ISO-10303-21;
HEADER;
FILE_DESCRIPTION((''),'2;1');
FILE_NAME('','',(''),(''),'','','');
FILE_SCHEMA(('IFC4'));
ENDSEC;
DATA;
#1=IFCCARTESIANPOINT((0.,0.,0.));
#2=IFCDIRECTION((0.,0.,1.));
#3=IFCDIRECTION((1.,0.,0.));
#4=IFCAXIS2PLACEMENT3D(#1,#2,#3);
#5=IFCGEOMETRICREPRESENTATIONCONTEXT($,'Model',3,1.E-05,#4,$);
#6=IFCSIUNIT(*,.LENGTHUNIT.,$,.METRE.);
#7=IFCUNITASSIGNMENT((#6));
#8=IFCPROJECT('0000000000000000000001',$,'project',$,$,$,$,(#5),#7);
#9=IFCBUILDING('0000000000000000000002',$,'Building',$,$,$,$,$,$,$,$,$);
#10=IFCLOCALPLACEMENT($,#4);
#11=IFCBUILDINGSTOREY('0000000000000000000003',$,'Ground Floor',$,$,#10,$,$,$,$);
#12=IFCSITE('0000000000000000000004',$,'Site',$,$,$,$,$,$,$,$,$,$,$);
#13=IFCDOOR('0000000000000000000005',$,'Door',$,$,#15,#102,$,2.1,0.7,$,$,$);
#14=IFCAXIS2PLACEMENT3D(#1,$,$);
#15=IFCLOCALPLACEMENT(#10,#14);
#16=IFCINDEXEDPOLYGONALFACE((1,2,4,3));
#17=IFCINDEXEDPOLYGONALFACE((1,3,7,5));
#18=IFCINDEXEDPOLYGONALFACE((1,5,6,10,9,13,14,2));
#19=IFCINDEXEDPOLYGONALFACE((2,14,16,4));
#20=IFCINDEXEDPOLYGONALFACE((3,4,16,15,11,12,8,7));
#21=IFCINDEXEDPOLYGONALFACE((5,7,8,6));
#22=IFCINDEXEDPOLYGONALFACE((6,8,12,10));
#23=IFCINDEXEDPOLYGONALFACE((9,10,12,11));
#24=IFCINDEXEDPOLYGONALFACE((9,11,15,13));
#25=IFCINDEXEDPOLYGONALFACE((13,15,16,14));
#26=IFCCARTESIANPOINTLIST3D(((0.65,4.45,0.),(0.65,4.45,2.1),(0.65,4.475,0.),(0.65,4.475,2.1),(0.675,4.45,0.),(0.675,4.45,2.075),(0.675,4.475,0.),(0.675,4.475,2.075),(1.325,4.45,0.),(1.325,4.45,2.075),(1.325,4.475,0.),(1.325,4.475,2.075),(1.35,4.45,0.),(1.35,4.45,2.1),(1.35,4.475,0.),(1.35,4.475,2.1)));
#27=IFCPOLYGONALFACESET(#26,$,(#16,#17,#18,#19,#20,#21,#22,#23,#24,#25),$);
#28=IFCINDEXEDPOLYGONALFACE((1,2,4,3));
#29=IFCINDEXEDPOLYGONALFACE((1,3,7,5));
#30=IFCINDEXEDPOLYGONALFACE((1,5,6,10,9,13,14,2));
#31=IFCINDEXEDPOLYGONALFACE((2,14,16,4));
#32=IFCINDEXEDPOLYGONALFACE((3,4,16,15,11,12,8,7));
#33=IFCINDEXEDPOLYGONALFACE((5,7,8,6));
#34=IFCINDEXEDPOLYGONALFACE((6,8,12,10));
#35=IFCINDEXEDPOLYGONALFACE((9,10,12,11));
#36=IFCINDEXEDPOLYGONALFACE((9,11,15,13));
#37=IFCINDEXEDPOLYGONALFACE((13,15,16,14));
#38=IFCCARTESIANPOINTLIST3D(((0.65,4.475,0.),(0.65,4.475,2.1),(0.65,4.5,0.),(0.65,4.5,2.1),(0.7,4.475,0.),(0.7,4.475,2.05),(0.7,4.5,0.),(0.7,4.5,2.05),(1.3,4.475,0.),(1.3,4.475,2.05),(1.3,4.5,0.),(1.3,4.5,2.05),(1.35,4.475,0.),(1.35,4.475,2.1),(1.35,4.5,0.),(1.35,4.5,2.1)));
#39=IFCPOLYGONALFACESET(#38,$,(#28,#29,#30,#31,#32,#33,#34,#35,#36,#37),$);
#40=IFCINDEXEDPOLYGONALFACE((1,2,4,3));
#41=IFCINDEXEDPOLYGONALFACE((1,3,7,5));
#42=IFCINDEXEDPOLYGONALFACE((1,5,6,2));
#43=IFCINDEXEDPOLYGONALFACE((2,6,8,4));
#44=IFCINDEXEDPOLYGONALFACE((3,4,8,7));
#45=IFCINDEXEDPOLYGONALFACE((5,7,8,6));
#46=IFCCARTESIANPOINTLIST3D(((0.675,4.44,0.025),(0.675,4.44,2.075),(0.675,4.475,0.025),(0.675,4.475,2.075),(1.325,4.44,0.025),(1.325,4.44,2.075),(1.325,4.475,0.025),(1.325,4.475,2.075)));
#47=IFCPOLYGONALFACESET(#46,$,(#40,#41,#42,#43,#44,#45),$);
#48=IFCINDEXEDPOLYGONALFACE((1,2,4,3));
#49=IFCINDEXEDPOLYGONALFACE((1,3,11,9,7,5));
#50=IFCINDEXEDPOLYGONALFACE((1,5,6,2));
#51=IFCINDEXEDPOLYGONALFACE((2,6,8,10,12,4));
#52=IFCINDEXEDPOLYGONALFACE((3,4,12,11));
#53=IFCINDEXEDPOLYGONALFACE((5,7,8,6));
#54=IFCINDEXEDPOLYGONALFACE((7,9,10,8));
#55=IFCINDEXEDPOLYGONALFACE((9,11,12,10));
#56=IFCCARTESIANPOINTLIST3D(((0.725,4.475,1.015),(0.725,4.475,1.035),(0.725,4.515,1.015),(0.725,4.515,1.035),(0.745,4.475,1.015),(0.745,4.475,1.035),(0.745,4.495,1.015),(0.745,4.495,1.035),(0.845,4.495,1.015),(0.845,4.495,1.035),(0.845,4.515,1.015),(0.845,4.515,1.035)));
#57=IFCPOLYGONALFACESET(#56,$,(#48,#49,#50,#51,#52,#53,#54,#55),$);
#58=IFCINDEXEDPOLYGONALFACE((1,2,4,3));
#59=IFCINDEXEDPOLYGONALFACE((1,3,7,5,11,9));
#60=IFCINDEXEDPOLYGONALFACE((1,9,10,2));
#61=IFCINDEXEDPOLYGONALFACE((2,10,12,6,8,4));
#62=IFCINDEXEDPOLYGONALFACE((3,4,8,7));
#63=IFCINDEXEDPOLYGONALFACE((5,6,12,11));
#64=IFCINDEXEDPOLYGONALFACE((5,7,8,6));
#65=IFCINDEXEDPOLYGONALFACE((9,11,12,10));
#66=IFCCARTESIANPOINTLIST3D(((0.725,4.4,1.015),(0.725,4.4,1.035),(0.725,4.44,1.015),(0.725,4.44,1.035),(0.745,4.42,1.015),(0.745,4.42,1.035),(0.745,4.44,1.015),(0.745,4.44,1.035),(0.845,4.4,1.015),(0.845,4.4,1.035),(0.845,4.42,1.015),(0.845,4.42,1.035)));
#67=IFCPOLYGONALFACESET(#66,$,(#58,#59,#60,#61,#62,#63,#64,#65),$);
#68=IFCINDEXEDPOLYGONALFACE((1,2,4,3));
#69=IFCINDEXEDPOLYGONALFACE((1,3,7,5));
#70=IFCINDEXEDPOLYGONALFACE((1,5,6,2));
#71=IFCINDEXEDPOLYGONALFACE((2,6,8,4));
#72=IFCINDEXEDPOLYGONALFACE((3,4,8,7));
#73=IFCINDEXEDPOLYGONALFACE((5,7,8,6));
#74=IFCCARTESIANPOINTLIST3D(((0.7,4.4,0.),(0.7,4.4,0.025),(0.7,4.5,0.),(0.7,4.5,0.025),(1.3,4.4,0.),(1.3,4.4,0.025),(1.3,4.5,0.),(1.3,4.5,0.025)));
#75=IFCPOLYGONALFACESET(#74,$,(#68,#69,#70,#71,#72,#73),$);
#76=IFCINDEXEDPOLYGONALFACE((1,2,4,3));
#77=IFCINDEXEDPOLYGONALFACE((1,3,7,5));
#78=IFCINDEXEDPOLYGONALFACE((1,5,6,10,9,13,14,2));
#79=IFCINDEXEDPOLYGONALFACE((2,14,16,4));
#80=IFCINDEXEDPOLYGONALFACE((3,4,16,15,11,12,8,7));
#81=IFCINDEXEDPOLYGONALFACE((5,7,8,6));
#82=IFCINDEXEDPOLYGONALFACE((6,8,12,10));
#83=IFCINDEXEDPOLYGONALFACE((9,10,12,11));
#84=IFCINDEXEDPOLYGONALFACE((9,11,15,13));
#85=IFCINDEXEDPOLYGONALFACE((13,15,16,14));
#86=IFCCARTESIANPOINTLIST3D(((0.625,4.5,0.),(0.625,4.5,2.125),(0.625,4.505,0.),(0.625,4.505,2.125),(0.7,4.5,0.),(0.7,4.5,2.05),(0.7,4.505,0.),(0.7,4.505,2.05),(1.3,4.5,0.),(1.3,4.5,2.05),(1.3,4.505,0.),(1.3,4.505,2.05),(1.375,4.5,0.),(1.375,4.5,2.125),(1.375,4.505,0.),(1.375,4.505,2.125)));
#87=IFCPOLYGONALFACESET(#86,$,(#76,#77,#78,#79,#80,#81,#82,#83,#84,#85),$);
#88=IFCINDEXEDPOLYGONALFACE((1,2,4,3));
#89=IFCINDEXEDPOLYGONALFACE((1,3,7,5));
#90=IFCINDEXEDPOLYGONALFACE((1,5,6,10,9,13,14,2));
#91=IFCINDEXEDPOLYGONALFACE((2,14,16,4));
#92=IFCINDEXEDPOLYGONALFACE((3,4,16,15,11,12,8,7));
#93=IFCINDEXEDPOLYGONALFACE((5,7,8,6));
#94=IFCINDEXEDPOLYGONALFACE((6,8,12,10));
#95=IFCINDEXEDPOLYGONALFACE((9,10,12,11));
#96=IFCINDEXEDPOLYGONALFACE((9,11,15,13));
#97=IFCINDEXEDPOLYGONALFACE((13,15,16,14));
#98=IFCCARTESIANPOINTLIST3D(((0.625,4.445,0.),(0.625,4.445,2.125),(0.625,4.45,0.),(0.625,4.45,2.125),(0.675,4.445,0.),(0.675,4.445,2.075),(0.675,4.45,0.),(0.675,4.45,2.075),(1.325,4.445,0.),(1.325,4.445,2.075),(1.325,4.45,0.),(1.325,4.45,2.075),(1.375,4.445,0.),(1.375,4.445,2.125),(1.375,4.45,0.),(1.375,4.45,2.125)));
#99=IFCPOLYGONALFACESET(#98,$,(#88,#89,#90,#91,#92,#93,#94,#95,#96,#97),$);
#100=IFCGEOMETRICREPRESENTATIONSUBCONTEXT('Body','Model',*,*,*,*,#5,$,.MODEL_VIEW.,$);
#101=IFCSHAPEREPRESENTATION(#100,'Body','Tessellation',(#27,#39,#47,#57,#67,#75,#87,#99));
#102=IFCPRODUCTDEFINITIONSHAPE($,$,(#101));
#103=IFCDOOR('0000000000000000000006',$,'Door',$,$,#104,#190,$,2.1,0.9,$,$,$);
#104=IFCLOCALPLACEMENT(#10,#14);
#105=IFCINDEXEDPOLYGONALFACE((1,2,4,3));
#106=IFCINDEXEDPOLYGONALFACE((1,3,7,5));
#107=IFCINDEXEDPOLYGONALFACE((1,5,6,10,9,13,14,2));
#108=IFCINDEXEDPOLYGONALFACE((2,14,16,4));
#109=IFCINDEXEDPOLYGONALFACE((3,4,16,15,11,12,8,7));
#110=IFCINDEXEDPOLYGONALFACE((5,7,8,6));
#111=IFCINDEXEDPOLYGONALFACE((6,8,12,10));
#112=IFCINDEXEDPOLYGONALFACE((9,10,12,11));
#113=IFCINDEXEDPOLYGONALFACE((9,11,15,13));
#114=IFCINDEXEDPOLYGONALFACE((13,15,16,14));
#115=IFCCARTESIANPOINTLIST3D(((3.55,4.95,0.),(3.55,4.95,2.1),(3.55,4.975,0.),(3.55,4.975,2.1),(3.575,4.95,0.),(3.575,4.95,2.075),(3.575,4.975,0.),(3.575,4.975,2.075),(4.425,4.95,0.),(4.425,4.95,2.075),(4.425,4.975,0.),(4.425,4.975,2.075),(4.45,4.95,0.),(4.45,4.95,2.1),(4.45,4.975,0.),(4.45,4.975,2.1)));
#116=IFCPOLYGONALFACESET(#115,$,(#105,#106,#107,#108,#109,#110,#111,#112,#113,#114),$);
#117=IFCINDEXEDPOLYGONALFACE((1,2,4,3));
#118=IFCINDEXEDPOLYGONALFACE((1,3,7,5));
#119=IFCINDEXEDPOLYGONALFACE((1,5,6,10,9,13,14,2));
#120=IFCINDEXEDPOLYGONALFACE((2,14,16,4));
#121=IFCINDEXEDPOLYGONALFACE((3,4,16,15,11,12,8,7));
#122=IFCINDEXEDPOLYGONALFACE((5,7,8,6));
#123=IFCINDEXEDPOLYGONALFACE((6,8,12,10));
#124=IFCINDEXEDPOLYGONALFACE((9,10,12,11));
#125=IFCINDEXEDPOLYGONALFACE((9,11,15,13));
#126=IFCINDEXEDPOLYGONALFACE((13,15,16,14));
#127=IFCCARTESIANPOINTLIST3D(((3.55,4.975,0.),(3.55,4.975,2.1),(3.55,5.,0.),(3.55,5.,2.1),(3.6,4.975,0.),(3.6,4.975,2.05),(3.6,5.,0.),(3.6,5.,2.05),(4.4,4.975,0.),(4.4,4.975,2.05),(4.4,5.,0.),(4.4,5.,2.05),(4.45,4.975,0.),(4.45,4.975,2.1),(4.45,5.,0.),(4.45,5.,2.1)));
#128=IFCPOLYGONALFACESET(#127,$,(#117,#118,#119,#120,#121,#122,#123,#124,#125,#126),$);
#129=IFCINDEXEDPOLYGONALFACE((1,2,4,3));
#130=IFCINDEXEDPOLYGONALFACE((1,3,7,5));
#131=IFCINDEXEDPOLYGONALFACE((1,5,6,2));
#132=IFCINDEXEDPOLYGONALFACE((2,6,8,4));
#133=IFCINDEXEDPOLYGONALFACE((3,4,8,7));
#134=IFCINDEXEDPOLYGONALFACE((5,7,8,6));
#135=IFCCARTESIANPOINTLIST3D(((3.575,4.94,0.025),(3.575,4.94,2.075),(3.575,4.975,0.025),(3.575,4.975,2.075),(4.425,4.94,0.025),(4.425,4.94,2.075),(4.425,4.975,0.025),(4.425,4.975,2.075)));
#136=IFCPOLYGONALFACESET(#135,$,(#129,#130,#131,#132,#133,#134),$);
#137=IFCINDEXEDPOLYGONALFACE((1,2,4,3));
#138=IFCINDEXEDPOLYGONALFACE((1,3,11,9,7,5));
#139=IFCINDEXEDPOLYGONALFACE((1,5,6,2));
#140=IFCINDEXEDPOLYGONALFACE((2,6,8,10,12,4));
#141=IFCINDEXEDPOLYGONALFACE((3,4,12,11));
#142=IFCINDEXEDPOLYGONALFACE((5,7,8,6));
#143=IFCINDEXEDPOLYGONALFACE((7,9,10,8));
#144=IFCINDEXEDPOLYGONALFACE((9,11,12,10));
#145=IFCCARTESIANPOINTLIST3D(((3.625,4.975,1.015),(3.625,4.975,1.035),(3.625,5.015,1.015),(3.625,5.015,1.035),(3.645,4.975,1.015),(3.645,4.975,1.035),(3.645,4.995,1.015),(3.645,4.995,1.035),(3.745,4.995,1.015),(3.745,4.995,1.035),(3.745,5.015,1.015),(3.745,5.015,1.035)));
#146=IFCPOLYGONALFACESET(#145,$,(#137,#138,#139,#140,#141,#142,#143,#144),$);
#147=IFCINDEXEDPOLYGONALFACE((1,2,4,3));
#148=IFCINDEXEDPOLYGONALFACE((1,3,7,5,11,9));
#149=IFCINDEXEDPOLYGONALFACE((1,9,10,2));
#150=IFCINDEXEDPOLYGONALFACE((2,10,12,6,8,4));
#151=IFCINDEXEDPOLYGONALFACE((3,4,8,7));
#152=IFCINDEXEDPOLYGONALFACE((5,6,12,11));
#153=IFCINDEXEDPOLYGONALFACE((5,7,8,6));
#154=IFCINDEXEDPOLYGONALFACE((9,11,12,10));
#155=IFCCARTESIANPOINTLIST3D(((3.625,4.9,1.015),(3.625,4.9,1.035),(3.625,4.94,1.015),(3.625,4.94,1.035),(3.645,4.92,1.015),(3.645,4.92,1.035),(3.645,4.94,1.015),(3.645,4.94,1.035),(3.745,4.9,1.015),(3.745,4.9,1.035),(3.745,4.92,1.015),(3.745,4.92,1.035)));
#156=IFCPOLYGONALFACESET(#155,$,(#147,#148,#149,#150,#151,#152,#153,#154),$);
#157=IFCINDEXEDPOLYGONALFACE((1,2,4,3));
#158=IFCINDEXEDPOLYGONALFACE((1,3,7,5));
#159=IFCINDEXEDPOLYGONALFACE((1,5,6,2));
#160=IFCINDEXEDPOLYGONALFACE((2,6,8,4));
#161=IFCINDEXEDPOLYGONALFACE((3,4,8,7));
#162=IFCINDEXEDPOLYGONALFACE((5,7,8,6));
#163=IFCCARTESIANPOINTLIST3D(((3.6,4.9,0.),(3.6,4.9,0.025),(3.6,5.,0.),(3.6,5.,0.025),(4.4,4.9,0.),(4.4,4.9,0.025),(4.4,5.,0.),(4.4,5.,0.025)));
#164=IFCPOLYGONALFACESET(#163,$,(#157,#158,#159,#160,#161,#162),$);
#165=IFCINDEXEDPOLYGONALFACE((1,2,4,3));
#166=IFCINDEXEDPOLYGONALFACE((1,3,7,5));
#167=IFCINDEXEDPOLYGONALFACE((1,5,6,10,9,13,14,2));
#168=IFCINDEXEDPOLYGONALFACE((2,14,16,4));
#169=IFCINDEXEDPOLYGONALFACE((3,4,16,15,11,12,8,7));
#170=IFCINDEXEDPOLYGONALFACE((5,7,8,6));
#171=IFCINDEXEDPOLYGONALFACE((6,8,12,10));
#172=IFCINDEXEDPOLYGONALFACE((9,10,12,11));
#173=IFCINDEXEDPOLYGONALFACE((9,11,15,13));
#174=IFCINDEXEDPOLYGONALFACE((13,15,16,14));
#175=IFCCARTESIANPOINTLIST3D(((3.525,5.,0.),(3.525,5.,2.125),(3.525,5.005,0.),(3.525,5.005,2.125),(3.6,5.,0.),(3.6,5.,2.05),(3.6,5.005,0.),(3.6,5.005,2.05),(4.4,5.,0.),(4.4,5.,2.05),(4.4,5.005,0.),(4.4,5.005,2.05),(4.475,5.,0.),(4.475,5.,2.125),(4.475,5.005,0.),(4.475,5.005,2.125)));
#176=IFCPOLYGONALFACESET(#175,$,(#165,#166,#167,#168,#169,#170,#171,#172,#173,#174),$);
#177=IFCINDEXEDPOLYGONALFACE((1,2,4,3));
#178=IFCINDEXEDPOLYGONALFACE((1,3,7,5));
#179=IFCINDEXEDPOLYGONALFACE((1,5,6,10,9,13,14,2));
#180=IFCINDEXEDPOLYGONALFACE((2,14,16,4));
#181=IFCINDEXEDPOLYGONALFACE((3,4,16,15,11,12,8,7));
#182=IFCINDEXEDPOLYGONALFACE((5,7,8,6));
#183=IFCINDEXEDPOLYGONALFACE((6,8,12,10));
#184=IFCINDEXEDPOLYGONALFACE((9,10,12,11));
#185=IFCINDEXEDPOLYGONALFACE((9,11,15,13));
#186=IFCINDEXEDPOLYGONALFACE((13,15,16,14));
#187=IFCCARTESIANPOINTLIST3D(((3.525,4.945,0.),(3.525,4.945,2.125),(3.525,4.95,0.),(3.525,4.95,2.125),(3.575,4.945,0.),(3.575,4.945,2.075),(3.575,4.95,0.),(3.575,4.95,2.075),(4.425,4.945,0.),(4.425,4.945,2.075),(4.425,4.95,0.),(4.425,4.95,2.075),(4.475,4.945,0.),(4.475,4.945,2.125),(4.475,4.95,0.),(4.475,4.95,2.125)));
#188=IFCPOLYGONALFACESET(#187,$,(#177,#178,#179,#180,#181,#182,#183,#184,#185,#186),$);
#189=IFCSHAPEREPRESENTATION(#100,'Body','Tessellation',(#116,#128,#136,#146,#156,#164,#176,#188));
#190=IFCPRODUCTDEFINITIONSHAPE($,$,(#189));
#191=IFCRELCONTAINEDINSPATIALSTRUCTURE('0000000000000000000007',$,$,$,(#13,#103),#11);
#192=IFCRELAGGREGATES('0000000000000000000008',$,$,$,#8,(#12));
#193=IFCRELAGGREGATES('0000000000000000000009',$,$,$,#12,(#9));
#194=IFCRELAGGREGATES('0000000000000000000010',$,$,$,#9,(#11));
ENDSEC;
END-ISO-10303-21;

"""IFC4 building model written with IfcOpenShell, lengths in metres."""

from ifc_helpers import new_model, si_unit, frame, origin_with_axes, place, context, subcontext, project, spatial, line, indexed_curve, outline, extrude, element, save


model = new_model("IFC4")

# Units and contexts
model_context = context("Model", 3, precision=1e-05, world=origin_with_axes())
body_context = subcontext(model_context, "Body", "Model", "MODEL_VIEW")
ifc_project = project(units=[si_unit("LENGTHUNIT", "METRE")], contexts=[model_context])

# Site, building, storey
site = spatial("IfcSite", under=ifc_project, Name="Site")
building = spatial("IfcBuilding", under=site, Name="Building")
storey_placement = place(None, origin_with_axes())
storey = spatial("IfcBuildingStorey", under=building, at=storey_placement, Name="Ground Floor")

# Doors
door_1_placement = place(storey_placement, frame((1.35, 4.5, 0.0), z_axis=(0.0, 0.0, 1.0), x_axis=(-1.0, 0.0, 0.0)))
element("IfcDoor", 1, at=door_1_placement, inside=storey, Name="Door", OverallHeight=2.1, OverallWidth=0.7, context=body_context, shape_type="SweptSolid", body=[
    extrude(outline(indexed_curve([(0.0, 0.0), (0.0, 2.1), (0.7, 2.1), (0.7, 0.0), (0.675, 0.0), (0.675, 2.075), (0.025, 2.075), (0.025, 0.0)], segments=[line(1, 2, 3, 4, 5, 6, 7, 8, 1)])), frame((0.0, 0.025, 0.0), z_axis=(0.0, -1.0, 0.0), x_axis=(1.0, 0.0, 0.0)), (0.0, 0.0, -1.0), 0.025),
    extrude(outline(indexed_curve([(0.0, 0.0), (0.0, 2.1), (0.7, 2.1), (0.7, 0.0), (0.65, 0.0), (0.65, 2.05), (0.05, 2.05), (0.05, 0.0)], segments=[line(1, 2, 3, 4, 5, 6, 7, 8, 1)])), frame((0.0, 0.0, 0.0), z_axis=(0.0, -1.0, 0.0), x_axis=(1.0, 0.0, 0.0)), (0.0, 0.0, -1.0), 0.025),
    extrude(outline(indexed_curve([(0.0, 0.0), (0.65, 0.0), (0.65, 0.035), (0.0, 0.035)], segments=[line(1, 2, 3, 4, 1)])), frame((0.025, 0.025, 0.025), z_axis=(0.0, 0.0, 1.0), x_axis=(1.0, 0.0, 0.0)), (0.0, 0.0, 1.0), 2.05),
    extrude(outline(indexed_curve([(0.0, 0.0), (0.0, -0.04), (-0.12, -0.04), (-0.12, -0.02), (-0.02, -0.02), (-0.02, 0.0)], segments=[line(1, 2, 3, 4, 5, 6, 1)])), frame((0.625, 0.025, 1.015), z_axis=(0.0, 0.0, 1.0), x_axis=(1.0, 0.0, 0.0)), (0.0, 0.0, 1.0), 0.02),
    extrude(outline(indexed_curve([(0.0, 0.0), (0.0, 0.04), (-0.12, 0.04), (-0.12, 0.02), (-0.02, 0.02), (-0.02, 0.0)], segments=[line(1, 2, 3, 4, 5, 6, 1)])), frame((0.625, 0.06, 1.015), z_axis=(0.0, 0.0, 1.0), x_axis=(1.0, 0.0, 0.0)), (0.0, 0.0, 1.0), 0.02),
    extrude(outline(indexed_curve([(0.0, 0.0), (0.6, 0.0), (0.6, 0.1), (0.0, 0.1)], segments=[line(1, 2, 3, 4, 1)])), frame((0.05, 0.0, 0.0), z_axis=(0.0, 0.0, 1.0), x_axis=(1.0, 0.0, 0.0)), (0.0, 0.0, 1.0), 0.025),
    extrude(outline(indexed_curve([(0.0, 0.0), (0.0, 2.125), (0.75, 2.125), (0.75, 0.0), (0.675, 0.0), (0.675, 2.05), (0.075, 2.05), (0.075, 0.0)], segments=[line(1, 2, 3, 4, 5, 6, 7, 8, 1)])), frame((-0.025, -0.005, 0.0), z_axis=(0.0, -1.0, 0.0), x_axis=(1.0, 0.0, 0.0)), (0.0, 0.0, -1.0), 0.005),
    extrude(outline(indexed_curve([(0.0, 0.0), (0.0, 2.125), (0.75, 2.125), (0.75, 0.0), (0.7, 0.0), (0.7, 2.075), (0.05, 2.075), (0.05, 0.0)], segments=[line(1, 2, 3, 4, 5, 6, 7, 8, 1)])), frame((-0.025, 0.05, 0.0), z_axis=(0.0, -1.0, 0.0), x_axis=(1.0, 0.0, 0.0)), (0.0, 0.0, -1.0), 0.005),
])
door_2_placement = place(storey_placement, frame((4.45, 5.0, 0.0), z_axis=(0.0, 0.0, 1.0), x_axis=(-1.0, 0.0, 0.0)))
element("IfcDoor", 2, at=door_2_placement, inside=storey, Name="Door", OverallHeight=2.1, OverallWidth=0.9, context=body_context, shape_type="SweptSolid", body=[
    extrude(outline(indexed_curve([(0.0, 0.0), (0.0, 2.1), (0.9, 2.1), (0.9, 0.0), (0.875, 0.0), (0.875, 2.075), (0.025, 2.075), (0.025, 0.0)], segments=[line(1, 2, 3, 4, 5, 6, 7, 8, 1)])), frame((0.0, 0.025, 0.0), z_axis=(0.0, -1.0, 0.0), x_axis=(1.0, 0.0, 0.0)), (0.0, 0.0, -1.0), 0.025),
    extrude(outline(indexed_curve([(0.0, 0.0), (0.0, 2.1), (0.9, 2.1), (0.9, 0.0), (0.85, 0.0), (0.85, 2.05), (0.05, 2.05), (0.05, 0.0)], segments=[line(1, 2, 3, 4, 5, 6, 7, 8, 1)])), frame((0.0, 0.0, 0.0), z_axis=(0.0, -1.0, 0.0), x_axis=(1.0, 0.0, 0.0)), (0.0, 0.0, -1.0), 0.025),
    extrude(outline(indexed_curve([(0.0, 0.0), (0.85, 0.0), (0.85, 0.035), (0.0, 0.035)], segments=[line(1, 2, 3, 4, 1)])), frame((0.025, 0.025, 0.025), z_axis=(0.0, 0.0, 1.0), x_axis=(1.0, 0.0, 0.0)), (0.0, 0.0, 1.0), 2.05),
    extrude(outline(indexed_curve([(0.0, 0.0), (0.0, -0.04), (-0.12, -0.04), (-0.12, -0.02), (-0.02, -0.02), (-0.02, 0.0)], segments=[line(1, 2, 3, 4, 5, 6, 1)])), frame((0.825, 0.025, 1.015), z_axis=(0.0, 0.0, 1.0), x_axis=(1.0, 0.0, 0.0)), (0.0, 0.0, 1.0), 0.02),
    extrude(outline(indexed_curve([(0.0, 0.0), (0.0, 0.04), (-0.12, 0.04), (-0.12, 0.02), (-0.02, 0.02), (-0.02, 0.0)], segments=[line(1, 2, 3, 4, 5, 6, 1)])), frame((0.825, 0.06, 1.015), z_axis=(0.0, 0.0, 1.0), x_axis=(1.0, 0.0, 0.0)), (0.0, 0.0, 1.0), 0.02),
    extrude(outline(indexed_curve([(0.0, 0.0), (0.8, 0.0), (0.8, 0.1), (0.0, 0.1)], segments=[line(1, 2, 3, 4, 1)])), frame((0.05, 0.0, 0.0), z_axis=(0.0, 0.0, 1.0), x_axis=(1.0, 0.0, 0.0)), (0.0, 0.0, 1.0), 0.025),
    extrude(outline(indexed_curve([(0.0, 0.0), (0.0, 2.125), (0.95, 2.125), (0.95, 0.0), (0.875, 0.0), (0.875, 2.05), (0.075, 2.05), (0.075, 0.0)], segments=[line(1, 2, 3, 4, 5, 6, 7, 8, 1)])), frame((-0.025, -0.005, 0.0), z_axis=(0.0, -1.0, 0.0), x_axis=(1.0, 0.0, 0.0)), (0.0, 0.0, -1.0), 0.005),
    extrude(outline(indexed_curve([(0.0, 0.0), (0.0, 2.125), (0.95, 2.125), (0.95, 0.0), (0.9, 0.0), (0.9, 2.075), (0.05, 2.075), (0.05, 0.0)], segments=[line(1, 2, 3, 4, 5, 6, 7, 8, 1)])), frame((-0.025, 0.05, 0.0), z_axis=(0.0, -1.0, 0.0), x_axis=(1.0, 0.0, 0.0)), (0.0, 0.0, -1.0), 0.005),
])

save(model, "model.ifc")
